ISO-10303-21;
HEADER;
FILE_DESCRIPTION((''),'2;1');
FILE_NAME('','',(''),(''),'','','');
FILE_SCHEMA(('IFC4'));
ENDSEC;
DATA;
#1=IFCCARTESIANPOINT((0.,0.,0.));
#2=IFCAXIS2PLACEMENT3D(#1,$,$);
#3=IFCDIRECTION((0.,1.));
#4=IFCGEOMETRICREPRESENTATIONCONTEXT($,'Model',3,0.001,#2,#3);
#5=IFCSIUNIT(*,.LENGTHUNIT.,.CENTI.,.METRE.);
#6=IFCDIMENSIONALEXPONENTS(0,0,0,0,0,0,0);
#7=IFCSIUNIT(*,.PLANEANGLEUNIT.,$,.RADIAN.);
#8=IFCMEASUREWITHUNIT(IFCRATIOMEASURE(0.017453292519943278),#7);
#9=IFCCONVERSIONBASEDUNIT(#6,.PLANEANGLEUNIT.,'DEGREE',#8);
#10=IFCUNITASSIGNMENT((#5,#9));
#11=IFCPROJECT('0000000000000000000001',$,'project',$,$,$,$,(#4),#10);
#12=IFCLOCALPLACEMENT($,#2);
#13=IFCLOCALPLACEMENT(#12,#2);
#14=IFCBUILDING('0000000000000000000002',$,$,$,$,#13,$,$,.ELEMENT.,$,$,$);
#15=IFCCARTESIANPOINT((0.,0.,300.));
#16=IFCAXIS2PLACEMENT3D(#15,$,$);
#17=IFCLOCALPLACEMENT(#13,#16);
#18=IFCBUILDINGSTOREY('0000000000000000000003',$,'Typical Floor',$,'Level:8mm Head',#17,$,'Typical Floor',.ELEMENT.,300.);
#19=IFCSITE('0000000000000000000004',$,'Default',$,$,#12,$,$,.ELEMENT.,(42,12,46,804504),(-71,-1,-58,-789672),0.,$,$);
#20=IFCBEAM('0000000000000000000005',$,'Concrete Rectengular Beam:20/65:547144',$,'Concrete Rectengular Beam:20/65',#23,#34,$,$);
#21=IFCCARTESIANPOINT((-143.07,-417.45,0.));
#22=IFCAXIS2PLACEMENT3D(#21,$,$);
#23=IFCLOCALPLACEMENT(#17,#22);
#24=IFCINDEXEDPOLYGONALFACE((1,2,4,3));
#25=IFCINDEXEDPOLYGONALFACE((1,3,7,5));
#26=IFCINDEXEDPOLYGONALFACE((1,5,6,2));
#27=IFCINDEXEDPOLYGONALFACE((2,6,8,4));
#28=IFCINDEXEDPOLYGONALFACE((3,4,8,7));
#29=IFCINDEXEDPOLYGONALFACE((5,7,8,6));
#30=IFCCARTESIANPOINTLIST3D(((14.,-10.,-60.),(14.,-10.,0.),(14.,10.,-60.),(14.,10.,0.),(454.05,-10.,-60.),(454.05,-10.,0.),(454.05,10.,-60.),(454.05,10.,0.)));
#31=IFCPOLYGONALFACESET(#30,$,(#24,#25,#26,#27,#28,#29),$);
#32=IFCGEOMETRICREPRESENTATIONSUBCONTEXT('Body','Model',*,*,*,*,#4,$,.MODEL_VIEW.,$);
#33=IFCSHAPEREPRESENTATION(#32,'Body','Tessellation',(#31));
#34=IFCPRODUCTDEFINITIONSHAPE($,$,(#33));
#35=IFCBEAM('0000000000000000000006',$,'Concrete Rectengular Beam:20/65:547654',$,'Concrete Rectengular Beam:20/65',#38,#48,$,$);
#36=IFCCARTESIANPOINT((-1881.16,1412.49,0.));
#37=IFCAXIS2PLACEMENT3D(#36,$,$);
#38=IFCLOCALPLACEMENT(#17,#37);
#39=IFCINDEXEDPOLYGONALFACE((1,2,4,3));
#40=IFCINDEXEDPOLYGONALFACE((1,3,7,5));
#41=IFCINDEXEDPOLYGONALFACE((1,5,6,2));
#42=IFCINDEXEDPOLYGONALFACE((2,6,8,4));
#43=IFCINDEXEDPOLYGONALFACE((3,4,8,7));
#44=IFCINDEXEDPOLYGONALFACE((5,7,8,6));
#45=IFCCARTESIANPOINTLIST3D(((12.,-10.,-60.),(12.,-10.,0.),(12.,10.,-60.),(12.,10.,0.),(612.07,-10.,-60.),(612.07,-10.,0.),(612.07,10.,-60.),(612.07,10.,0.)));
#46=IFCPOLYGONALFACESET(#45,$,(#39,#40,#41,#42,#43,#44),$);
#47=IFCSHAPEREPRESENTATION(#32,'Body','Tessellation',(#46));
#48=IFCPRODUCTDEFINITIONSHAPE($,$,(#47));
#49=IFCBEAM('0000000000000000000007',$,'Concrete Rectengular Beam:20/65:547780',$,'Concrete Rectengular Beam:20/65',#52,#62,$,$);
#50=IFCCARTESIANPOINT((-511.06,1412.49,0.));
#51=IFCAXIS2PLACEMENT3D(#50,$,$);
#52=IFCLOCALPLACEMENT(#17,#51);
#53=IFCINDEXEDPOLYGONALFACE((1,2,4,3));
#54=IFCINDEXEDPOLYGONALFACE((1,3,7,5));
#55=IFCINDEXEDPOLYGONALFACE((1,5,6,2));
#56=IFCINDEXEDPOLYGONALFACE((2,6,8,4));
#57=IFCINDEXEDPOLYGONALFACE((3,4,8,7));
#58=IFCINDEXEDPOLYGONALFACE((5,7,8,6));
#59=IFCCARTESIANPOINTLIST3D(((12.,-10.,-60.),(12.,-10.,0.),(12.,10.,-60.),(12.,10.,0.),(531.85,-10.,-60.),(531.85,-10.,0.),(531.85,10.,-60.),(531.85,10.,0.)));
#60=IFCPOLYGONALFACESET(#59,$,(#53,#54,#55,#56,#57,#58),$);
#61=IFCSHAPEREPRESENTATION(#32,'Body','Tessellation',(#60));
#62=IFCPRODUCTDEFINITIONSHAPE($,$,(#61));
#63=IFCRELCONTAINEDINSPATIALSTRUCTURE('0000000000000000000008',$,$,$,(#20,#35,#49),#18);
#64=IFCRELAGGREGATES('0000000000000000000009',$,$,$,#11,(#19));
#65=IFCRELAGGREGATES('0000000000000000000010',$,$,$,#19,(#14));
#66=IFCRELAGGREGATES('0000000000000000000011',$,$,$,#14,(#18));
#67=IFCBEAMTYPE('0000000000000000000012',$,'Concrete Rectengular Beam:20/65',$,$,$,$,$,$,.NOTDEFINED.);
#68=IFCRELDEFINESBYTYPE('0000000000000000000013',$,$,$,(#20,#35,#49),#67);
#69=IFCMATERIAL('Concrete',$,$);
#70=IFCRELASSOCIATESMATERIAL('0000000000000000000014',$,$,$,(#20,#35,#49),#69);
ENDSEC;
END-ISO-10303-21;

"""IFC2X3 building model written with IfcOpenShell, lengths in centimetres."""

from ifc_helpers import new_model, entity, si_unit, converted_unit, direction, frame, frame_2d, origin, place, context, subcontext, project, spatial, rectangle, extrude, material, type_object, element, save


model = new_model("IFC2X3")

# Units and contexts
model_context = context("Model", 3, precision=0.001, world=origin(), true_north=direction((0.0, 1.0)))
body_context = subcontext(model_context, "Body", "Model", "MODEL_VIEW")
ifc_project = project(units=[si_unit("LENGTHUNIT", "METRE", prefix="CENTI"), converted_unit("PLANEANGLEUNIT", "DEGREE", entity("IfcRatioMeasure", 0.017453292519943278), si_unit("PLANEANGLEUNIT", "RADIAN"), dimensions=[0, 0, 0, 0, 0, 0, 0])], contexts=[model_context])

# Site, building, storey
site_placement = place(None, origin())
site = spatial("IfcSite", under=ifc_project, at=site_placement, Name="Default", CompositionType="ELEMENT", RefLatitude=(42, 12, 46, 804504), RefLongitude=(-71, -1, -58, -789672), RefElevation=0.0)
building_placement = place(site_placement, origin())
building = spatial("IfcBuilding", under=site, at=building_placement, CompositionType="ELEMENT")
storey_placement = place(building_placement, frame((0.0, 0.0, 300.0)))
storey = spatial("IfcBuildingStorey", under=building, at=storey_placement, Name="Typical Floor", ObjectType="Level:8mm Head", LongName="Typical Floor", CompositionType="ELEMENT", Elevation=300.0)

# Beams
ifc_material = material(Name="Concrete")
beam_type_1 = type_object("IfcBeamType", Name="Concrete Rectengular Beam:20/65", PredefinedType="NOTDEFINED")
beam_1_placement = place(storey_placement, frame((-143.07, -417.45, 0.0)))
element("IfcBeam", 1, at=beam_1_placement, inside=storey, type_object=beam_type_1, material=ifc_material, Name="Concrete Rectengular Beam:20/65:547144", ObjectType="Concrete Rectengular Beam:20/65", context=body_context, shape_type="SweptSolid", body=[
    extrude(rectangle(XDim=60.0, YDim=20.0, at=frame_2d((0.0, 0.0), x_axis=(1.0, 0.0))), frame((14.0, 0.0, -30.0), z_axis=(1.0, 0.0, 0.0), x_axis=(0.0, 0.0, -1.0)), (0.0, 0.0, 1.0), 440.05),
])
beam_2_placement = place(storey_placement, frame((-1881.16, 1412.49, 0.0)))
element("IfcBeam", 2, at=beam_2_placement, inside=storey, type_object=beam_type_1, material=ifc_material, Name="Concrete Rectengular Beam:20/65:547654", ObjectType="Concrete Rectengular Beam:20/65", context=body_context, shape_type="SweptSolid", body=[
    extrude(rectangle(XDim=60.0, YDim=20.0, at=frame_2d((0.0, 0.0), x_axis=(1.0, 0.0))), frame((12.0, 0.0, -30.0), z_axis=(1.0, 0.0, 0.0), x_axis=(0.0, 0.0, -1.0)), (0.0, 0.0, 1.0), 600.07),
])
beam_3_placement = place(storey_placement, frame((-511.06, 1412.49, 0.0)))
element("IfcBeam", 3, at=beam_3_placement, inside=storey, type_object=beam_type_1, material=ifc_material, Name="Concrete Rectengular Beam:20/65:547780", ObjectType="Concrete Rectengular Beam:20/65", context=body_context, shape_type="SweptSolid", body=[
    extrude(rectangle(XDim=60.0, YDim=20.0, at=frame_2d((0.0, 0.0), x_axis=(1.0, 0.0))), frame((12.0, 0.0, -30.0), z_axis=(1.0, 0.0, 0.0), x_axis=(0.0, 0.0, -1.0)), (0.0, 0.0, 1.0), 519.85),
])

save(model, "model.ifc")
